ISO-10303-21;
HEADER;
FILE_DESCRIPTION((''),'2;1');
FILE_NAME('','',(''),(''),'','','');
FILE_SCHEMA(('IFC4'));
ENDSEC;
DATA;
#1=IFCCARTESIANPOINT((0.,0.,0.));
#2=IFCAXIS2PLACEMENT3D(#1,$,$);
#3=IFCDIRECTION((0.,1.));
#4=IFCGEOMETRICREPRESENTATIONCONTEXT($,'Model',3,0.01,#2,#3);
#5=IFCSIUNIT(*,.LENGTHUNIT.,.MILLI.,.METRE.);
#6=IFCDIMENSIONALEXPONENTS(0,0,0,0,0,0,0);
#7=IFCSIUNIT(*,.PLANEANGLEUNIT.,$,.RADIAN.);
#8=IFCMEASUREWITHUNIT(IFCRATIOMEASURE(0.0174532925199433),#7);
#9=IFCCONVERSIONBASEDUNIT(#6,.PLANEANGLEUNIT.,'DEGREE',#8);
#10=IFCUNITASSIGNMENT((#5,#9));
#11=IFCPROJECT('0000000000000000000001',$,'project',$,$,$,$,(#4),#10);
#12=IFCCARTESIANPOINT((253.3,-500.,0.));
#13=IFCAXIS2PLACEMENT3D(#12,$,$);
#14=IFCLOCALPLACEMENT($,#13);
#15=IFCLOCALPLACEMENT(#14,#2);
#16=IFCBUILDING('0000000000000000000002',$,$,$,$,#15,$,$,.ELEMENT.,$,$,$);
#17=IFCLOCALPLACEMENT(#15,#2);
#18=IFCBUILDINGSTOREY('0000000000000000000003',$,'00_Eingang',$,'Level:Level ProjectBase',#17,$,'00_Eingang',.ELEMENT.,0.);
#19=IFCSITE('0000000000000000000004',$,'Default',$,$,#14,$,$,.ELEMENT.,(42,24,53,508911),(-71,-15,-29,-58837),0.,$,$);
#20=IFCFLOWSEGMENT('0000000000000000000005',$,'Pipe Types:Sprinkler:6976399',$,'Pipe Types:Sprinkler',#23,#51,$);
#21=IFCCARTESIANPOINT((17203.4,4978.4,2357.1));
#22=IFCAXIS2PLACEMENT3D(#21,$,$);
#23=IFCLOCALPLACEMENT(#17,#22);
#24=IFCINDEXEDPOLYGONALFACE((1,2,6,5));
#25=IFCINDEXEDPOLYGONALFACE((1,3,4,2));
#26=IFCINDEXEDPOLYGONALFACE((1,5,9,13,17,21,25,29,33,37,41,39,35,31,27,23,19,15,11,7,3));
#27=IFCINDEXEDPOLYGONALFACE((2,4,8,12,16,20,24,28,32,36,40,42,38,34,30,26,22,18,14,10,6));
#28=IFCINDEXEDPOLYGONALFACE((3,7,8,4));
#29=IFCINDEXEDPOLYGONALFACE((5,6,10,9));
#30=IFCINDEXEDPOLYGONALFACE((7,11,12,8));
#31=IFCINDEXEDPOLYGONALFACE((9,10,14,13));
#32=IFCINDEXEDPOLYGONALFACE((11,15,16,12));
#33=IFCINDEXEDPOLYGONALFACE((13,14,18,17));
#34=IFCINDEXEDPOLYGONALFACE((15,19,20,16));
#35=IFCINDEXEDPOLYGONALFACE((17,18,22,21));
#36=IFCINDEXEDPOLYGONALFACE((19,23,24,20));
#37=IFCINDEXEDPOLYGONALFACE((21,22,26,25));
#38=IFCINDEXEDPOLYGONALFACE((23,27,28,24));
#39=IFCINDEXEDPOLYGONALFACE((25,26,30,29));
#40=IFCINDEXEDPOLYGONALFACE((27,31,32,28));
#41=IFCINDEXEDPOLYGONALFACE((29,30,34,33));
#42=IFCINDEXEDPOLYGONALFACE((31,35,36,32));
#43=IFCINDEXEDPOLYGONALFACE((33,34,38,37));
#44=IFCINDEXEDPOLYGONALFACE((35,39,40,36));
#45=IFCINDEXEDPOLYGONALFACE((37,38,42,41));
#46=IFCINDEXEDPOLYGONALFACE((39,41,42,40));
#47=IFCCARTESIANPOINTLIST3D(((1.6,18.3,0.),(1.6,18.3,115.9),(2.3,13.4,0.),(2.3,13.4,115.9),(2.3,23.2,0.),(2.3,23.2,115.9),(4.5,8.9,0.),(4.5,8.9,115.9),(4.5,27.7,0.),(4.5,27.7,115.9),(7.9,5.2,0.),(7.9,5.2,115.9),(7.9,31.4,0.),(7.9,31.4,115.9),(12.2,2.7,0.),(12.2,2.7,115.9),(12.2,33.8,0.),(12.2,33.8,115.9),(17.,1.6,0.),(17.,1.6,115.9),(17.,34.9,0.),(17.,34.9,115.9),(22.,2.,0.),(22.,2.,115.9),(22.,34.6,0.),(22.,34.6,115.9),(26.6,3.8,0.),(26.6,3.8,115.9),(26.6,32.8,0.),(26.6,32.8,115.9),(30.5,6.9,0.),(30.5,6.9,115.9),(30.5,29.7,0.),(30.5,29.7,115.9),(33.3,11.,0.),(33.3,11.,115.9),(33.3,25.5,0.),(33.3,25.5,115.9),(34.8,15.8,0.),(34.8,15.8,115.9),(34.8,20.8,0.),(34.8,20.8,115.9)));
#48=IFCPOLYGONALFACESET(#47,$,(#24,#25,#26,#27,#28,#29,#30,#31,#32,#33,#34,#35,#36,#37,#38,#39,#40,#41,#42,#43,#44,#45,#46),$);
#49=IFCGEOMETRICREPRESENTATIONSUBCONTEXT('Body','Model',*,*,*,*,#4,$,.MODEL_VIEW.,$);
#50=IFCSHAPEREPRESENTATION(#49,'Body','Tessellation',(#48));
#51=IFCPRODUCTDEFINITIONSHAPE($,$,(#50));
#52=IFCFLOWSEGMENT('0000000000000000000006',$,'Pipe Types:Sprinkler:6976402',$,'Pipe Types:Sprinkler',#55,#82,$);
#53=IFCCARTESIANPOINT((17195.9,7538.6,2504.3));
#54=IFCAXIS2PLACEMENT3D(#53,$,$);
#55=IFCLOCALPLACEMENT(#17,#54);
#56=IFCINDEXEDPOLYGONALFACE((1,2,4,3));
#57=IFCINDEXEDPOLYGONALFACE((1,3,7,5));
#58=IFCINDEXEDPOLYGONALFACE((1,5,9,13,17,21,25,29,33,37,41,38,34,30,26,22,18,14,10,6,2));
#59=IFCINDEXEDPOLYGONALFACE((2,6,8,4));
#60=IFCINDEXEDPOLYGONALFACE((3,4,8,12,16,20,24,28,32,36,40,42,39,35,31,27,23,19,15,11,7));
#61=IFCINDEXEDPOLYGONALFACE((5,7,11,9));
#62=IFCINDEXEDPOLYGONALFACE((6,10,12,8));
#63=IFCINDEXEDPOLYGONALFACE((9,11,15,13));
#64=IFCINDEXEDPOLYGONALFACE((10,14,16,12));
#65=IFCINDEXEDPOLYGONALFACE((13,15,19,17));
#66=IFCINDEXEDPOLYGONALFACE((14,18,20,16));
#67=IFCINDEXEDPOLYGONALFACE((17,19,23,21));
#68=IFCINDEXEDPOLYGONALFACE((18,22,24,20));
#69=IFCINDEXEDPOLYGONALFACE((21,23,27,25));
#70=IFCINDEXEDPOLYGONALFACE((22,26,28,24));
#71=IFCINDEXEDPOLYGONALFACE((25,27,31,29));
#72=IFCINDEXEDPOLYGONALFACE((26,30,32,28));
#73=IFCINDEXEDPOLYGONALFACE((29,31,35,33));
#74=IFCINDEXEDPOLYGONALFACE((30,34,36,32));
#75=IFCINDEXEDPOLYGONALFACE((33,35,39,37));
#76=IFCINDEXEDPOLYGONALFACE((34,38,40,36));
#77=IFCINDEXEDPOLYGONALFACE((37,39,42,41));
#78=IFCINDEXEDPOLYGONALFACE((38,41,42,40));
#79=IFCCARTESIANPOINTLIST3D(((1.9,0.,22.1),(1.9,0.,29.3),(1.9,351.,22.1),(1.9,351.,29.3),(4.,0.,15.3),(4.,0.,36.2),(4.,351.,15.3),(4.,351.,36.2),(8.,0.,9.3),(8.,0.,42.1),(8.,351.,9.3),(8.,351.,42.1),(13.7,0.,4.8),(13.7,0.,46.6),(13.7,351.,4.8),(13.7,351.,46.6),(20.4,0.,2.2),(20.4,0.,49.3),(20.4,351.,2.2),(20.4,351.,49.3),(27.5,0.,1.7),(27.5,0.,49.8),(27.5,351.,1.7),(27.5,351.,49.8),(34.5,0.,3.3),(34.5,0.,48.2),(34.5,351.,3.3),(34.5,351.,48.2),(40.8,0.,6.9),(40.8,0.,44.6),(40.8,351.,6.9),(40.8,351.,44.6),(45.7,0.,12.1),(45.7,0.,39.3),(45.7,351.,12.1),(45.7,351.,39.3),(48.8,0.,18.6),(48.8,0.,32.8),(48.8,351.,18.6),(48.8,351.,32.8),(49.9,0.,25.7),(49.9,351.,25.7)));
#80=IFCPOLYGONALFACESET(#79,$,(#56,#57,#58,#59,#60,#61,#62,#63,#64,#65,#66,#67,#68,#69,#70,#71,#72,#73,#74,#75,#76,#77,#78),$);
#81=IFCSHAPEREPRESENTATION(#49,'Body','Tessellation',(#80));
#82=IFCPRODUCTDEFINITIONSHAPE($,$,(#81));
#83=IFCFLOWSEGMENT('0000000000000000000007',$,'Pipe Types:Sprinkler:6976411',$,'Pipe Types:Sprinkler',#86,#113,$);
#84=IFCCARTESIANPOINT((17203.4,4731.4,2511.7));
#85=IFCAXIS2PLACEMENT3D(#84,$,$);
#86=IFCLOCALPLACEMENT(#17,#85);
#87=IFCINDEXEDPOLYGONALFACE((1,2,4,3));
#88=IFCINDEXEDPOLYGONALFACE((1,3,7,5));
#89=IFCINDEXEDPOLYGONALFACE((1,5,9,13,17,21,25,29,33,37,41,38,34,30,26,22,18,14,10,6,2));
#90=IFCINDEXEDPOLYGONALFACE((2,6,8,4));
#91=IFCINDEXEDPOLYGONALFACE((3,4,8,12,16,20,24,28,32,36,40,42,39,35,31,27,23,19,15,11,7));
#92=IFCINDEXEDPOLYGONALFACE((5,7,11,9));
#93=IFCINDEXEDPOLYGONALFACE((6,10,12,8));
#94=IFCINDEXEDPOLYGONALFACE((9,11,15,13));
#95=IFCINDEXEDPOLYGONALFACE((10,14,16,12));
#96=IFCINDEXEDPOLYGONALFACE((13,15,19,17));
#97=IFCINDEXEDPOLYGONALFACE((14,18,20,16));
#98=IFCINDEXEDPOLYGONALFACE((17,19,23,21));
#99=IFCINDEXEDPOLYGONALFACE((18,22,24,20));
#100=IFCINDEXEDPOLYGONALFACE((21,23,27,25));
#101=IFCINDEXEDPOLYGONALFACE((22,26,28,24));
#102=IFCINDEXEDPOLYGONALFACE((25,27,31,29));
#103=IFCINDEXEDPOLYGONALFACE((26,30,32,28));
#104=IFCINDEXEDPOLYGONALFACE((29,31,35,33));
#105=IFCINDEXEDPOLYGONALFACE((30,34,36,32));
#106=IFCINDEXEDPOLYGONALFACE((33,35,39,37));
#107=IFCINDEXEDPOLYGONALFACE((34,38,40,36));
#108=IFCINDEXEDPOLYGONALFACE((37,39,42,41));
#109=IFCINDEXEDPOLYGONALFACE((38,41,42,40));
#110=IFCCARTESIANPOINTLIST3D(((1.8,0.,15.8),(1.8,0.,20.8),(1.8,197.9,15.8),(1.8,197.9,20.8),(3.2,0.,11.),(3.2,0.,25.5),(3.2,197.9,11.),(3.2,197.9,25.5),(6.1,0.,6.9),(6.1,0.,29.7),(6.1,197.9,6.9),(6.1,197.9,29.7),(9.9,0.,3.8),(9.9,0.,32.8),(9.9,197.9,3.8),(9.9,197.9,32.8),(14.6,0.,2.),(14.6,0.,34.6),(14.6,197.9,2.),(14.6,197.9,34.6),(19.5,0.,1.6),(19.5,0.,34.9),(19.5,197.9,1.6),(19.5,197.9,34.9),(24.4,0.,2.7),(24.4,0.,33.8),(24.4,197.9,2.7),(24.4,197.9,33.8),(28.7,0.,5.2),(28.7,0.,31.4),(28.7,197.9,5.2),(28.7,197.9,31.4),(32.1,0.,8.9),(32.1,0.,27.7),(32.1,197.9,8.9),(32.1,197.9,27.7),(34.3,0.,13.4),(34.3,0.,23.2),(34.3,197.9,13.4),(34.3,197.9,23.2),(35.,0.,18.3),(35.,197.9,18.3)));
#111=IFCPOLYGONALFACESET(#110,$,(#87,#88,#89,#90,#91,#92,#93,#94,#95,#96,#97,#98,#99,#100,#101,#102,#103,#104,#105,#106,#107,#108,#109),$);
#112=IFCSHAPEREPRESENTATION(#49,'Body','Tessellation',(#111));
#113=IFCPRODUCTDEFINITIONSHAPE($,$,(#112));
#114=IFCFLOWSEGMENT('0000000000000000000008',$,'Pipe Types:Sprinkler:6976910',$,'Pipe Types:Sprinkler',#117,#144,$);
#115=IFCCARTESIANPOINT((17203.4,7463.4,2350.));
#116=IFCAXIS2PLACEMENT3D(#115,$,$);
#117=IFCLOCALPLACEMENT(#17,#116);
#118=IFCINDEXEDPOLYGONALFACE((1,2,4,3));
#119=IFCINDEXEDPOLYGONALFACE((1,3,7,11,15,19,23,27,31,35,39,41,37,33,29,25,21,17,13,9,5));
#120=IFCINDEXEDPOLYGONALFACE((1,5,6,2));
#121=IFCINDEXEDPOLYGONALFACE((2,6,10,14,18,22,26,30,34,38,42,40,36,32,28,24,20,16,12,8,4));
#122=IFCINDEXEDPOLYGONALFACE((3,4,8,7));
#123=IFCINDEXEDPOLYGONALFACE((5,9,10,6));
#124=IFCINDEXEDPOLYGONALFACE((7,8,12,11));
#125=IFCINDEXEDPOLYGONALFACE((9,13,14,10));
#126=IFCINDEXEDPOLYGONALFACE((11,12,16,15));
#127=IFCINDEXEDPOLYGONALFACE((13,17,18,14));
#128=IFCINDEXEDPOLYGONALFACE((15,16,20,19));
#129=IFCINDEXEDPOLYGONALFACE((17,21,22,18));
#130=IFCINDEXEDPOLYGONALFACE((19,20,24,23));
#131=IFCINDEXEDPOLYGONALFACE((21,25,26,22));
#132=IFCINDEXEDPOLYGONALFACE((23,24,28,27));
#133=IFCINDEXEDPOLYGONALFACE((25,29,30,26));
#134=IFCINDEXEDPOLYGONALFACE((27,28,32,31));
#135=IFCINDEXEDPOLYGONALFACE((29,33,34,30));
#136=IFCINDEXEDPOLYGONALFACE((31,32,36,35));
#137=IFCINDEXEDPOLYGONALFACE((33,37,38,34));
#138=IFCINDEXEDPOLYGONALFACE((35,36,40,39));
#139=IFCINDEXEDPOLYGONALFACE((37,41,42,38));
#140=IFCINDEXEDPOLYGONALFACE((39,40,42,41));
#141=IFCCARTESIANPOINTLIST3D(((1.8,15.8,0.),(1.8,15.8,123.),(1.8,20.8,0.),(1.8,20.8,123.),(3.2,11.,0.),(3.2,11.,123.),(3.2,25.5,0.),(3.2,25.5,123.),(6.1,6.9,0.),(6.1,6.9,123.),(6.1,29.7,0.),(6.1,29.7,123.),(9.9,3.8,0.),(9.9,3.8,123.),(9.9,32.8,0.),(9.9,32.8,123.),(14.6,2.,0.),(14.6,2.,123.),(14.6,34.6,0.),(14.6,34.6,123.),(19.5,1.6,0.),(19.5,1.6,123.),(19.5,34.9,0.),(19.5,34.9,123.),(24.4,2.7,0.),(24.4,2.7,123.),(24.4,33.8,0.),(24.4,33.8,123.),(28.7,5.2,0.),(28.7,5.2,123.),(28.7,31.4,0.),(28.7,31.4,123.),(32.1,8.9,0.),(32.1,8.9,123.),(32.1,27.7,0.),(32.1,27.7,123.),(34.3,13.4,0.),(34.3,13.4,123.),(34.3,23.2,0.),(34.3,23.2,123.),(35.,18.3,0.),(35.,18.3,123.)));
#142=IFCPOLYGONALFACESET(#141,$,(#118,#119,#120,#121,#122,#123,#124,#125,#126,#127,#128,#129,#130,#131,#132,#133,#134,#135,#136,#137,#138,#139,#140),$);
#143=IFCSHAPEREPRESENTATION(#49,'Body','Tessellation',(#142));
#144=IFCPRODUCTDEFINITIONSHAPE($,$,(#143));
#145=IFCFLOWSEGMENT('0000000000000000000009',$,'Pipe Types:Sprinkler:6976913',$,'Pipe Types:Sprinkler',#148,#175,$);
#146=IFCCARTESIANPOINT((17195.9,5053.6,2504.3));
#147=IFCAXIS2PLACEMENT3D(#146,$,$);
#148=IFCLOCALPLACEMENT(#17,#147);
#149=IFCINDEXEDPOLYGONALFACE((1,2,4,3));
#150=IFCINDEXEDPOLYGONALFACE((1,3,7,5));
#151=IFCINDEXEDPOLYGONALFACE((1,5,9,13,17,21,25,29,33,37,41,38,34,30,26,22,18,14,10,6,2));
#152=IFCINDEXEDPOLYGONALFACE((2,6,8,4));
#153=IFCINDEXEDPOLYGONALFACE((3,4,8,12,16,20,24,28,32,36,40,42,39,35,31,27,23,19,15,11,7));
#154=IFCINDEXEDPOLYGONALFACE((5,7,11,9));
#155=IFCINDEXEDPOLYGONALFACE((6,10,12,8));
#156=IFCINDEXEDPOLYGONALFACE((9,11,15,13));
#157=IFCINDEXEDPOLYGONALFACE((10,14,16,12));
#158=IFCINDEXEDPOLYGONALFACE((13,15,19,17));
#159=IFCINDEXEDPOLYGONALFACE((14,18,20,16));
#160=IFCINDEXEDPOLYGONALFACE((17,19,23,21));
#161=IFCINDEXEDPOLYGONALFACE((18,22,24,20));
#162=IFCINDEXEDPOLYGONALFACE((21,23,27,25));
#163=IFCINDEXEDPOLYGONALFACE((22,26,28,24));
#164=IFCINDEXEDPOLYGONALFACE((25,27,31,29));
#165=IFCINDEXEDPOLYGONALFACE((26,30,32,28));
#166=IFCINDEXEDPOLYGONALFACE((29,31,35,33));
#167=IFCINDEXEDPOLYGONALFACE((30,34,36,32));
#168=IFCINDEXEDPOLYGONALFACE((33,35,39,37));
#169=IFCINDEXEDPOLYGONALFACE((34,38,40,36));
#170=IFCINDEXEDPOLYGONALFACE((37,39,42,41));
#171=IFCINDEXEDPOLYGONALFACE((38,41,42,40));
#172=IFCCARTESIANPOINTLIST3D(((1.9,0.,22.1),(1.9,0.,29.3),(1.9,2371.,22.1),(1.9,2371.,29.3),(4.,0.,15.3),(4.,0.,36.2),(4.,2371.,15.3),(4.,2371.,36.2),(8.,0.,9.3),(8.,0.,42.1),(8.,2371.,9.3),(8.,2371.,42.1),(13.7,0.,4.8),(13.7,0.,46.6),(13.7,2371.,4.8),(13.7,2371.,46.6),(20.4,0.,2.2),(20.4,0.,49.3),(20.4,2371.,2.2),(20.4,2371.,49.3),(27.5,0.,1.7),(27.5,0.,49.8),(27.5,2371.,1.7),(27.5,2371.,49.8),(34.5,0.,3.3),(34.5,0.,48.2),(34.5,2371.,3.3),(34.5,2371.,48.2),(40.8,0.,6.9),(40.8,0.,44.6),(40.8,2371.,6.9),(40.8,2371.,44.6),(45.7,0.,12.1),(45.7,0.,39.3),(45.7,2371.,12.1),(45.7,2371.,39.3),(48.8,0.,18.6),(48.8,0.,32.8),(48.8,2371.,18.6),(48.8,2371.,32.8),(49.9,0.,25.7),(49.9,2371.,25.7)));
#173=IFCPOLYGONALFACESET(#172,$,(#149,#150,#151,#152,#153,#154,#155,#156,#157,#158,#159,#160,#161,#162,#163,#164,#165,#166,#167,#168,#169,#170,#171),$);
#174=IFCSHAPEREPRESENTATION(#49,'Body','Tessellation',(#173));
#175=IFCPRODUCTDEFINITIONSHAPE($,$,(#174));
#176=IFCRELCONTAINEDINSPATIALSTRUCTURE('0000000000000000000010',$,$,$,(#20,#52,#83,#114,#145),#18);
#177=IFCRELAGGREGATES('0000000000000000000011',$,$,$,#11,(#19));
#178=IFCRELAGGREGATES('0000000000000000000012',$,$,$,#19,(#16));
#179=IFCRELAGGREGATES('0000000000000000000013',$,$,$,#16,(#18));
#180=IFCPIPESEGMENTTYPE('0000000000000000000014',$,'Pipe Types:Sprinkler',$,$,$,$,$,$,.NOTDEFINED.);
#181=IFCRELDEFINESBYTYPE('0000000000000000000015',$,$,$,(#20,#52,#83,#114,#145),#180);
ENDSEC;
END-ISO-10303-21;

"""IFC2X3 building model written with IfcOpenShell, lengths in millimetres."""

from ifc_helpers import new_model, entity, si_unit, converted_unit, direction, frame, frame_2d, origin, origin_2d_with_axis, place, context, subcontext, project, spatial, circle, extrude, type_object, element, save


model = new_model("IFC2X3")

# Units and contexts
model_context = context("Model", 3, precision=0.01, world=origin(), true_north=direction((0.0, 1.0)))
body_context = subcontext(model_context, "Body", "Model", "MODEL_VIEW")
ifc_project = project(units=[si_unit("LENGTHUNIT", "METRE", prefix="MILLI"), converted_unit("PLANEANGLEUNIT", "DEGREE", entity("IfcRatioMeasure", 0.0174532925199433), si_unit("PLANEANGLEUNIT", "RADIAN"), dimensions=[0, 0, 0, 0, 0, 0, 0])], contexts=[model_context])

# Site, building, storey
site_placement = place(None, frame((253.3, -500.0, 0.0)))
site = spatial("IfcSite", under=ifc_project, at=site_placement, Name="Default", CompositionType="ELEMENT", RefLatitude=(42, 24, 53, 508911), RefLongitude=(-71, -15, -29, -58837), RefElevation=0.0)
building_placement = place(site_placement, origin())
building = spatial("IfcBuilding", under=site, at=building_placement, CompositionType="ELEMENT")
storey_placement = place(building_placement, origin())
storey = spatial("IfcBuildingStorey", under=building, at=storey_placement, Name="00_Eingang", ObjectType="Level:Level ProjectBase", LongName="00_Eingang", CompositionType="ELEMENT", Elevation=0.0)

# Flow segments
pipe_segment_type = type_object("IfcPipeSegmentType", Name="Pipe Types:Sprinkler", PredefinedType="NOTDEFINED")
flow_segment_1_placement = place(storey_placement, frame((17203.4, 4978.4, 2357.1)))
element("IfcFlowSegment", 1, at=flow_segment_1_placement, inside=storey, type_object=pipe_segment_type, Name="Pipe Types:Sprinkler:6976399", ObjectType="Pipe Types:Sprinkler", context=body_context, shape_type="SweptSolid", body=[
    extrude(circle(Radius=16.7, at=origin_2d_with_axis()), frame((18.3, 18.3, 0.0), z_axis=(0.0, 0.0, 1.0), x_axis=(-1.0, 0.0, 0.0)), (0.0, 0.0, 1.0), 115.9),
])
flow_segment_2_placement = place(storey_placement, frame((17195.9, 7538.6, 2504.3)))
element("IfcFlowSegment", 2, at=flow_segment_2_placement, inside=storey, type_object=pipe_segment_type, Name="Pipe Types:Sprinkler:6976402", ObjectType="Pipe Types:Sprinkler", context=body_context, shape_type="SweptSolid", body=[
    extrude(circle(Radius=24.1, at=origin_2d_with_axis()), frame((25.7, 0.0, 25.7), z_axis=(0.0, 1.0, 0.0), x_axis=(1.0, 0.0, 0.0)), (0.0, 0.0, 1.0), 351.0),
])
flow_segment_3_placement = place(storey_placement, frame((17203.4, 4731.4, 2511.7)))
element("IfcFlowSegment", 3, at=flow_segment_3_placement, inside=storey, type_object=pipe_segment_type, Name="Pipe Types:Sprinkler:6976411", ObjectType="Pipe Types:Sprinkler", context=body_context, shape_type="SweptSolid", body=[
    extrude(circle(Radius=16.7, at=frame_2d((0.0, 0.0), x_axis=(1.0, 0.0))), frame((18.3, 0.0, 18.3), z_axis=(0.0, 1.0, 0.0), x_axis=(1.0, 0.0, 0.0)), (0.0, 0.0, 1.0), 197.9),
])
flow_segment_4_placement = place(storey_placement, frame((17203.4, 7463.4, 2350.0)))
element("IfcFlowSegment", 4, at=flow_segment_4_placement, inside=storey, type_object=pipe_segment_type, Name="Pipe Types:Sprinkler:6976910", ObjectType="Pipe Types:Sprinkler", context=body_context, shape_type="SweptSolid", body=[
    extrude(circle(Radius=16.7, at=origin_2d_with_axis()), frame((18.3, 18.3, 0.0)), (0.0, 0.0, 1.0), 123.0),
])
flow_segment_5_placement = place(storey_placement, frame((17195.9, 5053.6, 2504.3)))
element("IfcFlowSegment", 5, at=flow_segment_5_placement, inside=storey, type_object=pipe_segment_type, Name="Pipe Types:Sprinkler:6976913", ObjectType="Pipe Types:Sprinkler", context=body_context, shape_type="SweptSolid", body=[
    extrude(circle(Radius=24.1, at=origin_2d_with_axis()), frame((25.7, 0.0, 25.7), z_axis=(0.0, 1.0, 0.0), x_axis=(1.0, 0.0, 0.0)), (0.0, 0.0, 1.0), 2371.0),
])

save(model, "model.ifc")
